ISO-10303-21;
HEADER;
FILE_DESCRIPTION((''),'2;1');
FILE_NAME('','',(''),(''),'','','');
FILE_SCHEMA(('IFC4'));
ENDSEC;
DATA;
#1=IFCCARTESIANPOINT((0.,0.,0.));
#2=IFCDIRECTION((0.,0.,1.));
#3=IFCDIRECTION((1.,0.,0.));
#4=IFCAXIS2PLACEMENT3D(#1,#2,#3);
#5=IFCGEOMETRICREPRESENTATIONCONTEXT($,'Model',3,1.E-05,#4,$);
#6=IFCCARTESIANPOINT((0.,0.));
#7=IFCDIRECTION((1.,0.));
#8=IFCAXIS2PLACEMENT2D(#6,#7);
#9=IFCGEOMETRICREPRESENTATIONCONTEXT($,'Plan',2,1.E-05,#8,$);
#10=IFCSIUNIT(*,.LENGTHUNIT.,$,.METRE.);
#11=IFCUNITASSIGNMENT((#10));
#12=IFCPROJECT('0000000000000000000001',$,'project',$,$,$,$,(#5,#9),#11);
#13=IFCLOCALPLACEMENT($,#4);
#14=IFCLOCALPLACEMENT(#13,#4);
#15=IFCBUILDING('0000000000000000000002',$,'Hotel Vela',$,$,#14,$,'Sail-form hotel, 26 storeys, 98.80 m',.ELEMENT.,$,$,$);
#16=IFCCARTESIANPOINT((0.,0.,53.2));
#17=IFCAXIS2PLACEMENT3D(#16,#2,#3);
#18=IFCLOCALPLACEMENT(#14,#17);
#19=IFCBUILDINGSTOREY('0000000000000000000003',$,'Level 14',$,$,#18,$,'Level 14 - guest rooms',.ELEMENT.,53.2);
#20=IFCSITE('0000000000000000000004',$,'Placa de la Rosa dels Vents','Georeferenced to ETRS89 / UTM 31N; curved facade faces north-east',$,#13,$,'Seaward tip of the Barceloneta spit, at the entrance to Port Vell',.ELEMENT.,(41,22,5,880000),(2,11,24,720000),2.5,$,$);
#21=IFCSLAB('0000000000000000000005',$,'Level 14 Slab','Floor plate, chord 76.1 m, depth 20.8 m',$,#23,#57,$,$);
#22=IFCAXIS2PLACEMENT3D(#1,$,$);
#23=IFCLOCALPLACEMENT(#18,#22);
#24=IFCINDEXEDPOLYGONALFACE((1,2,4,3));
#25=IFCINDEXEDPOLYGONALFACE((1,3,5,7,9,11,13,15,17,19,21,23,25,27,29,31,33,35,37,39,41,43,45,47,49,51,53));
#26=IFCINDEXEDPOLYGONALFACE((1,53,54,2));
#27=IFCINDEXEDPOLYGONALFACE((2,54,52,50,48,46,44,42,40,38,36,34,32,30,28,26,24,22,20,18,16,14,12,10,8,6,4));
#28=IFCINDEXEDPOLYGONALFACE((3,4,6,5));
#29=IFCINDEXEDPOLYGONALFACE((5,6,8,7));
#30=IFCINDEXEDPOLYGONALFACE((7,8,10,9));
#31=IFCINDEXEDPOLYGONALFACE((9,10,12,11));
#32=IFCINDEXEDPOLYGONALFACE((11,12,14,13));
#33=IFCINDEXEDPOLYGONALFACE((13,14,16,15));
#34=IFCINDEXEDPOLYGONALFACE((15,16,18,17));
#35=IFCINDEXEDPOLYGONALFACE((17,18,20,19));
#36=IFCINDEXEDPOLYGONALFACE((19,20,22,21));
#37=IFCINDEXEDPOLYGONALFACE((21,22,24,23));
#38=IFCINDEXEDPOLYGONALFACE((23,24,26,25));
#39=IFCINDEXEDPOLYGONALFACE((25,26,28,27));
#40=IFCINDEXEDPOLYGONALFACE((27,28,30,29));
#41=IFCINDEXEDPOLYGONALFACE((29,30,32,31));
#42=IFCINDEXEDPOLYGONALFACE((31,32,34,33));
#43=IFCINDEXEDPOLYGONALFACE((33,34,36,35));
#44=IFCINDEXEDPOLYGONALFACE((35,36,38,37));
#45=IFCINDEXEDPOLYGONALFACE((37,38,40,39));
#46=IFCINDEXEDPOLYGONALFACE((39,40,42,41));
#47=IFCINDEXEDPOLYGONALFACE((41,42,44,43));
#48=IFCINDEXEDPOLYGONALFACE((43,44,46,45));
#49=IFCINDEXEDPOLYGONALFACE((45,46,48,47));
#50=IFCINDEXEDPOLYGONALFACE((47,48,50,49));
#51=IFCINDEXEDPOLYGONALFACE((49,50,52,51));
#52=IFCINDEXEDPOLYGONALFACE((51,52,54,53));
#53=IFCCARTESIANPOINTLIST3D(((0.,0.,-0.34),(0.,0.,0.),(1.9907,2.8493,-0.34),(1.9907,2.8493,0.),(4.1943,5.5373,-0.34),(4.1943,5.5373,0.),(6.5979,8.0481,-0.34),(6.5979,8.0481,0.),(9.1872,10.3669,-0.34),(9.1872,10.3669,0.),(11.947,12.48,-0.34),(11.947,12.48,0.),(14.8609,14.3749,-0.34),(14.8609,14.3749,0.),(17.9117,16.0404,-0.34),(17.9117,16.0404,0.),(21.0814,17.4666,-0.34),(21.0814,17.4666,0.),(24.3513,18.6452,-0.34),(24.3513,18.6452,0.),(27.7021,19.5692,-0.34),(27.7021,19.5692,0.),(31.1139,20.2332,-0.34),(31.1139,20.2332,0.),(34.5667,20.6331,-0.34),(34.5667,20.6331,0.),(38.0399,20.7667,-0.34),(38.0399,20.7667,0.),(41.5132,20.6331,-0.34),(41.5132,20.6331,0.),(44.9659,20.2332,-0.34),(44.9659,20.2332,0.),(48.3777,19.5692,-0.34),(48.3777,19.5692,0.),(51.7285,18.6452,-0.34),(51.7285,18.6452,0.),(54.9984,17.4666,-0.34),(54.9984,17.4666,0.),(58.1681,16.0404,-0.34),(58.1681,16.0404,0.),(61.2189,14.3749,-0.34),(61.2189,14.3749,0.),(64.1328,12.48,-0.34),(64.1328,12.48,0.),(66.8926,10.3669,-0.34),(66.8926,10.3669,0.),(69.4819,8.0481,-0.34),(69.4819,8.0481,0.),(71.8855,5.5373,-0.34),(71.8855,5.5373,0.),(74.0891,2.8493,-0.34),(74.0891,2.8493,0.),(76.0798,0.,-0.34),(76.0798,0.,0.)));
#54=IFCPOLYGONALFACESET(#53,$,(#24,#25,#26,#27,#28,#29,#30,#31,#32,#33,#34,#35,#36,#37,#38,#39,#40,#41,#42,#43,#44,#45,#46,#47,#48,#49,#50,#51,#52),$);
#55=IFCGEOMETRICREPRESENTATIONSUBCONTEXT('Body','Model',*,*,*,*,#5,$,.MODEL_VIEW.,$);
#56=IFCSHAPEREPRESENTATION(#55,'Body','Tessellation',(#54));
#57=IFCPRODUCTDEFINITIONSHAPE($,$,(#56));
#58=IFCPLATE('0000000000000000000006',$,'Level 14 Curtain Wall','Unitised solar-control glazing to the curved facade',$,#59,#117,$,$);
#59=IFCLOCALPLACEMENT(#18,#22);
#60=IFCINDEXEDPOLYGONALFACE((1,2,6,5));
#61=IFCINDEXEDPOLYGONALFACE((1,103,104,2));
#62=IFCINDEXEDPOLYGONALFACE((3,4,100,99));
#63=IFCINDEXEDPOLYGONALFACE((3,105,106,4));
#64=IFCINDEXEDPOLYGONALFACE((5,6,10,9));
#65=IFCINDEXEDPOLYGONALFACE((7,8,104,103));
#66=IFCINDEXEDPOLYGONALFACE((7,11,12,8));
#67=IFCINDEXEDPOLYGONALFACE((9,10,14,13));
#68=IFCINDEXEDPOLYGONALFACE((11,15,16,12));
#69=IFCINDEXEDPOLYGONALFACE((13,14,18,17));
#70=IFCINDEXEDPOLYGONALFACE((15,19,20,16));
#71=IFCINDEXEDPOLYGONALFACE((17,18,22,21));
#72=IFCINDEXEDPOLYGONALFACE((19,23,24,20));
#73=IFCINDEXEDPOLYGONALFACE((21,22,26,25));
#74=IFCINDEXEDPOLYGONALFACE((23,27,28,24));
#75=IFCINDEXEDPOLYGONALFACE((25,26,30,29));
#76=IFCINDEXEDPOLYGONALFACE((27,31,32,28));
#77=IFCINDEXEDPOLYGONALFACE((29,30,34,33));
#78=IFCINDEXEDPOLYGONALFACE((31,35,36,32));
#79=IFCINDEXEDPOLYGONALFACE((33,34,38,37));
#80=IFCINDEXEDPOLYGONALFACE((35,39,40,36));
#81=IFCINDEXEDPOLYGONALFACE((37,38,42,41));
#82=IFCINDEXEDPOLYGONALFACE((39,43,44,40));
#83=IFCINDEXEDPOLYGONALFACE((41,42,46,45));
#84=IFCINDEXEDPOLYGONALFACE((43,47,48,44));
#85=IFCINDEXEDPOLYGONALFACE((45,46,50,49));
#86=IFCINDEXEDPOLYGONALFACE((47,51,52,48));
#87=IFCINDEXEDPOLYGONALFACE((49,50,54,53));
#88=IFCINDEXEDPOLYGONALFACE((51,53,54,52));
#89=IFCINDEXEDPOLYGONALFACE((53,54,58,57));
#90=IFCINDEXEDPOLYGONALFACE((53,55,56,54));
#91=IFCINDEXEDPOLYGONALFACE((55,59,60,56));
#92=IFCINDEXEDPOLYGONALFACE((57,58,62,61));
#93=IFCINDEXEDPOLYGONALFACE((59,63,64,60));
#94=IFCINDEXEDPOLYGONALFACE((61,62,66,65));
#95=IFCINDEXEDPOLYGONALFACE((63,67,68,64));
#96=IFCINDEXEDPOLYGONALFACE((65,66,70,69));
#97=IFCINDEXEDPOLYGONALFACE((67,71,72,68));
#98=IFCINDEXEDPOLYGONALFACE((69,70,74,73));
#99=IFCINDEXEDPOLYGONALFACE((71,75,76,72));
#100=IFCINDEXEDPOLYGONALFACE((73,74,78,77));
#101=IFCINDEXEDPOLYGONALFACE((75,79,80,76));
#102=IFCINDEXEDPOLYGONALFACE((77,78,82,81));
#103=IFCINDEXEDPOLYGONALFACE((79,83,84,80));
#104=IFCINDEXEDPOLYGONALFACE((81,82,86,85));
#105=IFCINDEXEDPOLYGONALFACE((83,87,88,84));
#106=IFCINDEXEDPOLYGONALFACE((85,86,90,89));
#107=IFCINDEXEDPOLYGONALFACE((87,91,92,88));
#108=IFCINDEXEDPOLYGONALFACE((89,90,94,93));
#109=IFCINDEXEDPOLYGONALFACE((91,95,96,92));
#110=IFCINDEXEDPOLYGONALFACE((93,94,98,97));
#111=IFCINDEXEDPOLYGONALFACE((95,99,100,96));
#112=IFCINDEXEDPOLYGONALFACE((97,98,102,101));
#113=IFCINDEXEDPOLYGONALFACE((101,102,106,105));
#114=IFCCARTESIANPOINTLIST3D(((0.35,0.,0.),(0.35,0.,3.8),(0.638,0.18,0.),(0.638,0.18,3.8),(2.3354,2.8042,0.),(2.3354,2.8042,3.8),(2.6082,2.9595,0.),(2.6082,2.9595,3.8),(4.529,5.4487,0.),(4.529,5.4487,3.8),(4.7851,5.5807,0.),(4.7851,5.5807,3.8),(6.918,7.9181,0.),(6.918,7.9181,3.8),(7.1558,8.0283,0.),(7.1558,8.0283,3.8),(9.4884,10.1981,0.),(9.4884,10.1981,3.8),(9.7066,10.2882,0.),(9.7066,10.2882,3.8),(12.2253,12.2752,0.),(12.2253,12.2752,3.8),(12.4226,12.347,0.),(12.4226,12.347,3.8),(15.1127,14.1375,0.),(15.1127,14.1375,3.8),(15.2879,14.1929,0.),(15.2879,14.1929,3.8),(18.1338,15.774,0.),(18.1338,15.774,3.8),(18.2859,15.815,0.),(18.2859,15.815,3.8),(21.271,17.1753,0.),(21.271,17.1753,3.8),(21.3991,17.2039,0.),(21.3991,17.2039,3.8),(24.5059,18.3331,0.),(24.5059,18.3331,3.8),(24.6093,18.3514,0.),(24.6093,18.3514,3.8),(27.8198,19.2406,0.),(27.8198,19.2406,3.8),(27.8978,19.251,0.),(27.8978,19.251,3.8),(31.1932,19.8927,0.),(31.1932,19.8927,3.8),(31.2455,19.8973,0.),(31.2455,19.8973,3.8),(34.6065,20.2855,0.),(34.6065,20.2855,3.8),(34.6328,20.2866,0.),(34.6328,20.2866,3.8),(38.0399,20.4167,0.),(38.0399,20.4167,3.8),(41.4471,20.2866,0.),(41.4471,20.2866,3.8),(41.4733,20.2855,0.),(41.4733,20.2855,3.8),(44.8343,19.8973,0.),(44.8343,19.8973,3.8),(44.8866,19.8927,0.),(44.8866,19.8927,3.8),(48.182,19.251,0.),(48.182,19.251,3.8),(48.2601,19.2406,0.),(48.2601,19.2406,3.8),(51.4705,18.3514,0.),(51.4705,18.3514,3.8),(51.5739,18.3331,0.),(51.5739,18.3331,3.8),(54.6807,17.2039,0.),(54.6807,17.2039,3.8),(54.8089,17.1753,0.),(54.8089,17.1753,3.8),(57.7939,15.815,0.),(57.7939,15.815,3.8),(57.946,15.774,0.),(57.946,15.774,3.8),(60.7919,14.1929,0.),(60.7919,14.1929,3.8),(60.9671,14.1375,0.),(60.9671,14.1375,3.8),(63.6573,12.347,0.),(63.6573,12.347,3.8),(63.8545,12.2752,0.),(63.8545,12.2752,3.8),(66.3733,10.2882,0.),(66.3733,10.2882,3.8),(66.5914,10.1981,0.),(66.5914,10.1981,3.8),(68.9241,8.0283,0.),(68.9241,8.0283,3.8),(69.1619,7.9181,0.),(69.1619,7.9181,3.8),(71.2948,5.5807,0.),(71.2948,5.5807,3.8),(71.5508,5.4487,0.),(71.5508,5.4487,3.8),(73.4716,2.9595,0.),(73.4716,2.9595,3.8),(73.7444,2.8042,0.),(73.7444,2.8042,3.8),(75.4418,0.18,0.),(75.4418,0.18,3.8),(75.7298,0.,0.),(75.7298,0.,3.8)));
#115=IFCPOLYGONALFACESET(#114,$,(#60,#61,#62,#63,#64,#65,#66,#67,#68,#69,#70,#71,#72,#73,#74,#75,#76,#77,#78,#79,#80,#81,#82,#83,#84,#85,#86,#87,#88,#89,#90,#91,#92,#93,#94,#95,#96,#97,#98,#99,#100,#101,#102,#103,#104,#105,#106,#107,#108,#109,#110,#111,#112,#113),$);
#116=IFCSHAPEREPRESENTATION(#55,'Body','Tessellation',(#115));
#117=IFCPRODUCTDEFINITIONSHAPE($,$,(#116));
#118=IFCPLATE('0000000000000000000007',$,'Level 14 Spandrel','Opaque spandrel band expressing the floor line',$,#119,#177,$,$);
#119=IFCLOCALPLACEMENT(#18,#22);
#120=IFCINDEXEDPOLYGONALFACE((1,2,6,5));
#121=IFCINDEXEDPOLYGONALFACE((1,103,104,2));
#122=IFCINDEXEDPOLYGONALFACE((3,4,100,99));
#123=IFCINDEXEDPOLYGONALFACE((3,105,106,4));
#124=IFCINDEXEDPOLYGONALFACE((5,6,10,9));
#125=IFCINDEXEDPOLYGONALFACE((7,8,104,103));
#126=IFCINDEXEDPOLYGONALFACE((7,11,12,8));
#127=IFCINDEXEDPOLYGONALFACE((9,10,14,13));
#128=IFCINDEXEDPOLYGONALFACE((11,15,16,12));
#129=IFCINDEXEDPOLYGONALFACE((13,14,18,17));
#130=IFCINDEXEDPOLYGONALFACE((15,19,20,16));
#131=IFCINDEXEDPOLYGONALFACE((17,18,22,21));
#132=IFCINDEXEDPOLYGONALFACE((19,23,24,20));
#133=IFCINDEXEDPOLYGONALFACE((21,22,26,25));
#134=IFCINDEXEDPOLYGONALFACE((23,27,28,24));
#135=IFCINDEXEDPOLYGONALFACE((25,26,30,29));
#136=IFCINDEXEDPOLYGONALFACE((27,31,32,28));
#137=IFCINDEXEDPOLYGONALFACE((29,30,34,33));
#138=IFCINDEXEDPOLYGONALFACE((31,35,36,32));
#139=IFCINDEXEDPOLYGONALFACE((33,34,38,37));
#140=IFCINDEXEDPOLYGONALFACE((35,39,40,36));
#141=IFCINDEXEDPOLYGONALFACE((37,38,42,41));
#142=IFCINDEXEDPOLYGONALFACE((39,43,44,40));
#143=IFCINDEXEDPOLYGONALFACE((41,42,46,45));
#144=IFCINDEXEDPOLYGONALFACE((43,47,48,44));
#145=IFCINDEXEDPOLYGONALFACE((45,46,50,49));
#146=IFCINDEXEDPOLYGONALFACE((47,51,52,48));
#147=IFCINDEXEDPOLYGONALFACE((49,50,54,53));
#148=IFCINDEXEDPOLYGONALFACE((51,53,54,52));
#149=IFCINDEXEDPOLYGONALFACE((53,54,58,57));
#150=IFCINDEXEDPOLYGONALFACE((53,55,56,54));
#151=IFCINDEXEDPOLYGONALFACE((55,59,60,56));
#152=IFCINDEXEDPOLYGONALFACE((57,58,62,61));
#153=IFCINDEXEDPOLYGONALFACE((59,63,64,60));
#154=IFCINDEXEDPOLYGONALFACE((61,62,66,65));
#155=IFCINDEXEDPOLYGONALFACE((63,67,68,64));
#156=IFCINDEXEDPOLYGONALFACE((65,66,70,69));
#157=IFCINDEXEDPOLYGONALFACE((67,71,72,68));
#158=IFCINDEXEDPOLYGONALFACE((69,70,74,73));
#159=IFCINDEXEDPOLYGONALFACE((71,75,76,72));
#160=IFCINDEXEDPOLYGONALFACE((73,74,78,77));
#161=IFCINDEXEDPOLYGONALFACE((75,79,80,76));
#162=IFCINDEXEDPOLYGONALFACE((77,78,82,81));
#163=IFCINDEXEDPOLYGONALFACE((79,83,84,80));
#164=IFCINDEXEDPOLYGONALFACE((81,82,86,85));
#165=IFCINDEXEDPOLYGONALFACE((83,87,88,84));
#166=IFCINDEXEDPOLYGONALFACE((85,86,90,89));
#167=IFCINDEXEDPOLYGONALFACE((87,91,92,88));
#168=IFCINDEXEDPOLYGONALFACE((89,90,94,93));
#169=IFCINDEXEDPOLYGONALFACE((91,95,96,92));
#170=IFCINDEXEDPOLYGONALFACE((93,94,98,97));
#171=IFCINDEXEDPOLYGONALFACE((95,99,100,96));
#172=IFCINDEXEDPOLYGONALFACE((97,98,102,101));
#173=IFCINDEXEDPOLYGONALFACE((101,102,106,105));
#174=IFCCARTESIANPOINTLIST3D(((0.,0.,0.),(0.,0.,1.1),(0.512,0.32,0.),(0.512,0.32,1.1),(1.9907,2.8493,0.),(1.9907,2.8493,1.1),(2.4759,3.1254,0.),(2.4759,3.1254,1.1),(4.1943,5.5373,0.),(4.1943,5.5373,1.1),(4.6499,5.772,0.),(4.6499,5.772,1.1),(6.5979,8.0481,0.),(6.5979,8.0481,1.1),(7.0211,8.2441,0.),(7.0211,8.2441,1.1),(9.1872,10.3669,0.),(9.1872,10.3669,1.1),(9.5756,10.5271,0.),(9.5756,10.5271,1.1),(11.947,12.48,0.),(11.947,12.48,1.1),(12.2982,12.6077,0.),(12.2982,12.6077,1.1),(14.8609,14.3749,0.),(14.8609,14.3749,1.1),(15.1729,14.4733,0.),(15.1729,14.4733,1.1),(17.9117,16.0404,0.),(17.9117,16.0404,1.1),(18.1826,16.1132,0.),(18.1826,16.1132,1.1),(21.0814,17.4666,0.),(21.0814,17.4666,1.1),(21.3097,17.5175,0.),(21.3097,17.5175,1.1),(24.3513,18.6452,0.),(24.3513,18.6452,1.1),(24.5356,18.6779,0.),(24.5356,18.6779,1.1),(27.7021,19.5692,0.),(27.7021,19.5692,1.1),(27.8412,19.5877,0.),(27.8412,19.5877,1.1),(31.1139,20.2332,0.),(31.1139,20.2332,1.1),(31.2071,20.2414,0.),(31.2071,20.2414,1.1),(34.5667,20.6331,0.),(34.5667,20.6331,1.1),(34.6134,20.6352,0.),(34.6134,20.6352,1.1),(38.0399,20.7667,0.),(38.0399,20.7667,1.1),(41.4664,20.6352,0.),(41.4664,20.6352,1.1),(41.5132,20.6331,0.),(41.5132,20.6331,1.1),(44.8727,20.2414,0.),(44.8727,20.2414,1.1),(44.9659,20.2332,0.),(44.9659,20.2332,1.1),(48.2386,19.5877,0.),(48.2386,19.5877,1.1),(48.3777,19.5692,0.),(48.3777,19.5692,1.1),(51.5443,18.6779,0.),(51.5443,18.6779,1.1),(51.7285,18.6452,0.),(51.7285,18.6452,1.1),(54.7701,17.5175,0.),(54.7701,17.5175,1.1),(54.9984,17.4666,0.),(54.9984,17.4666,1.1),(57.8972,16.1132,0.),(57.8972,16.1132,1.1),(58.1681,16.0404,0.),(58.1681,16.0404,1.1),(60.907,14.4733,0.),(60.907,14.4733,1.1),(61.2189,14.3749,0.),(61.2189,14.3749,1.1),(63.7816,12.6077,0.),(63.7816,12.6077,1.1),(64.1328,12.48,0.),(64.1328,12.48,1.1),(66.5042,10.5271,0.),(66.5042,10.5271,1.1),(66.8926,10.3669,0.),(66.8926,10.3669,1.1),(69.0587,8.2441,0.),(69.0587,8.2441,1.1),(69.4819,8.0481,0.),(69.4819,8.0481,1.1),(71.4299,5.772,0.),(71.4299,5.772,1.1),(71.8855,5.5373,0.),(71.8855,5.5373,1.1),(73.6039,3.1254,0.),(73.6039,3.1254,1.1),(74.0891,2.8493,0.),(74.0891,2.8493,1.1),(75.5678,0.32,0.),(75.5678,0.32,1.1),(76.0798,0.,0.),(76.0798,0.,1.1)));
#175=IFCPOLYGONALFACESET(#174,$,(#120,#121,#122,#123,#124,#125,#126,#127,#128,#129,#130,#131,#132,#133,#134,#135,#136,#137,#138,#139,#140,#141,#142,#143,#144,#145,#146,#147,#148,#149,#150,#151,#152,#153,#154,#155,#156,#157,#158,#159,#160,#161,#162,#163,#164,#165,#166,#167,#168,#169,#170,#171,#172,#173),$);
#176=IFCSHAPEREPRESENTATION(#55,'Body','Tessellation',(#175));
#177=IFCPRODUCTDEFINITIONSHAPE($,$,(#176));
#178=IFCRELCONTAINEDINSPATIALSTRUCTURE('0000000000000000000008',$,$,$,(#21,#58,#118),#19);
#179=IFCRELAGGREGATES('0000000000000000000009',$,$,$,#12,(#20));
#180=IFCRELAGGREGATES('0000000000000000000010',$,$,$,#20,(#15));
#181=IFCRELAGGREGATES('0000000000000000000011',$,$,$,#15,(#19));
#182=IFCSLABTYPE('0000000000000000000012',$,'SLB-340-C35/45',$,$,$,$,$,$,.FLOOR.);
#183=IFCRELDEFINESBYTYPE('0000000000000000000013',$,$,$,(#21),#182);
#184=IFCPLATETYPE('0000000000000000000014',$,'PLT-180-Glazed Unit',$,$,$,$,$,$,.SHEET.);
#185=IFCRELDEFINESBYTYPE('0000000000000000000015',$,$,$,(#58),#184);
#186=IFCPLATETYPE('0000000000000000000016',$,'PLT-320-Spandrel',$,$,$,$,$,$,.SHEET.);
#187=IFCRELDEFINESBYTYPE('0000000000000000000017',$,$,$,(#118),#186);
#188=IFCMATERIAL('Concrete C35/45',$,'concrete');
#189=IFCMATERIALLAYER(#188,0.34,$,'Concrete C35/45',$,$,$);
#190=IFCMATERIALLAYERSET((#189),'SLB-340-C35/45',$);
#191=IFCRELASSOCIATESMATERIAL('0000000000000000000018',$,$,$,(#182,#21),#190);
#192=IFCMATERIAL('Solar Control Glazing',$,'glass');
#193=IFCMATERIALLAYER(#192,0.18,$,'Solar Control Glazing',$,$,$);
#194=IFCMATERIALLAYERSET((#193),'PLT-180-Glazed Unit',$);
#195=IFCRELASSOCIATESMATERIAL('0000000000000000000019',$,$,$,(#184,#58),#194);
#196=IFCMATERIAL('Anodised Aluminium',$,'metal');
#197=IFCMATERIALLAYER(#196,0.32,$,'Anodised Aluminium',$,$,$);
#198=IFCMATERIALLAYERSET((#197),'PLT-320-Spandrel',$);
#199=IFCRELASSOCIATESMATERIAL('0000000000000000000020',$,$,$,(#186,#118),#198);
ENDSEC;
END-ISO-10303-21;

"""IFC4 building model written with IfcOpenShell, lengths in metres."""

from ifc_helpers import new_model, si_unit, frame, origin_with_axes, origin_2d_with_axis, place, context, subcontext, project, spatial, line, indexed_curve, outline, extrude, material, layer, layer_set, layer_usage, type_object, element, save


model = new_model("IFC4")

# Units and contexts
model_context = context("Model", 3, precision=1e-05, world=origin_with_axes())
plan_context = context("Plan", 2, precision=1e-05, world=origin_2d_with_axis())
body_context = subcontext(model_context, "Body", "Model", "MODEL_VIEW")
ifc_project = project(units=[si_unit("LENGTHUNIT", "METRE")], contexts=[model_context, plan_context])

# Site, building, storey
site_placement = place(None, origin_with_axes())
site = spatial("IfcSite", under=ifc_project, at=site_placement, Name="Placa de la Rosa dels Vents", Description="Georeferenced to ETRS89 / UTM 31N; curved facade faces north-east", LongName="Seaward tip of the Barceloneta spit, at the entrance to Port Vell", CompositionType="ELEMENT", RefLatitude=(41, 22, 5, 880000), RefLongitude=(2, 11, 24, 720000), RefElevation=2.5)
building_placement = place(site_placement, origin_with_axes())
building = spatial("IfcBuilding", under=site, at=building_placement, Name="Hotel Vela", LongName="Sail-form hotel, 26 storeys, 98.80 m", CompositionType="ELEMENT")
storey_placement = place(building_placement, frame((0.0, 0.0, 53.2), z_axis=(0.0, 0.0, 1.0), x_axis=(1.0, 0.0, 0.0)))
storey = spatial("IfcBuildingStorey", under=building, at=storey_placement, Name="Level 14", LongName="Level 14 - guest rooms", CompositionType="ELEMENT", Elevation=53.2)

# Slab
ifc_material_1 = material(Name="Concrete C35/45", Category="concrete")
ifc_layer_1 = layer(ifc_material_1, 0.34, Name="Concrete C35/45")
ifc_layer_set_1 = layer_set([ifc_layer_1], Name="SLB-340-C35/45")
ifc_layer_usage_1 = layer_usage(ifc_layer_set_1, "AXIS3", "POSITIVE", 0.0)
slab_type = type_object("IfcSlabType", Name="SLB-340-C35/45", PredefinedType="FLOOR", material=ifc_layer_set_1)
slab_placement = place(storey_placement, frame((0.0, 0.0, -0.34), z_axis=(0.0, 0.0, 1.0), x_axis=(1.0, 0.0, 0.0)))
element("IfcSlab", 1, at=slab_placement, inside=storey, type_object=slab_type, material=ifc_layer_usage_1, Name="Level 14 Slab", Description="Floor plate, chord 76.1 m, depth 20.8 m", context=body_context, shape_type="SweptSolid", body=[
    extrude(outline(indexed_curve([(0.0, 0.0), (76.0798, 0.0), (74.0891, 2.8493), (71.8855, 5.5373), (69.4819, 8.0481), (66.8926, 10.3669), (64.1328, 12.48), (61.2189, 14.3749), (58.1681, 16.0404), (54.9984, 17.4666), (51.7285, 18.6452), (48.3777, 19.5692), (44.9659, 20.2332), (41.5132, 20.6331), (38.0399, 20.7667), (34.5667, 20.6331), (31.1139, 20.2332), (27.7021, 19.5692), (24.3513, 18.6452), (21.0814, 17.4666), (17.9117, 16.0404), (14.8609, 14.3749), (11.947, 12.48), (9.1872, 10.3669), (6.5979, 8.0481), (4.1943, 5.5373), (1.9907, 2.8493)], segments=[line(1, 2, 3, 4, 5, 6, 7, 8, 9, 10, 11, 12, 13, 14, 15, 16, 17, 18, 19, 20, 21, 22, 23, 24, 25, 26, 27, 1)])), origin_with_axes(), (0.0, 0.0, 1.0), 0.34),
])

# Plates
ifc_material_2 = material(Name="Solar Control Glazing", Category="glass")
ifc_layer_2 = layer(ifc_material_2, 0.18, Name="Solar Control Glazing")
ifc_layer_set_2 = layer_set([ifc_layer_2], Name="PLT-180-Glazed Unit")
ifc_layer_usage_2 = layer_usage(ifc_layer_set_2, "AXIS2", "POSITIVE", 0.0)
plate_type_1 = type_object("IfcPlateType", Name="PLT-180-Glazed Unit", PredefinedType="SHEET", material=ifc_layer_set_2)
plate_1_placement = place(storey_placement, frame((0.35, 0.0, 0.0), z_axis=(0.0, 0.0, 1.0), x_axis=(1.0, 0.0, 0.0)))
element("IfcPlate", 2, at=plate_1_placement, inside=storey, type_object=plate_type_1, material=ifc_layer_usage_2, Name="Level 14 Curtain Wall", Description="Unitised solar-control glazing to the curved facade", context=body_context, shape_type="SweptSolid", body=[
    extrude(outline(indexed_curve([(75.3798, 0.0), (73.3944, 2.8042), (71.2008, 5.4487), (68.8119, 7.9181), (66.2414, 10.1981), (63.5045, 12.2752), (60.6171, 14.1375), (57.596, 15.774), (54.4589, 17.1753), (51.2239, 18.3331), (47.9101, 19.2406), (44.5366, 19.8927), (41.1233, 20.2855), (37.6899, 20.4167), (34.2565, 20.2855), (30.8432, 19.8927), (27.4698, 19.2406), (24.1559, 18.3331), (20.921, 17.1753), (17.7838, 15.774), (14.7627, 14.1375), (11.8753, 12.2752), (9.1384, 10.1981), (6.568, 7.9181), (4.179, 5.4487), (1.9854, 2.8042), (0.0, 0.0), (75.0918, 0.18), (2.2582, 2.9595), (4.4351, 5.5807), (6.8058, 8.0283), (9.3566, 10.2882), (12.0726, 12.347), (14.9379, 14.1929), (17.9359, 15.815), (21.0491, 17.2039), (24.2593, 18.3514), (27.5478, 19.251), (30.8955, 19.8973), (34.2828, 20.2866), (37.6899, 20.4167), (41.0971, 20.2866), (44.4843, 19.8973), (47.832, 19.251), (51.1205, 18.3514), (54.3307, 17.2039), (57.4439, 15.815), (60.4419, 14.1929), (63.3073, 12.347), (66.0233, 10.2882), (68.5741, 8.0283), (70.9448, 5.5807), (73.1216, 2.9595), (0.288, 0.18)], segments=[line(1, 2, 3, 4, 5, 6, 7, 8, 9, 10, 11, 12, 13, 14, 15, 16, 17, 18, 19, 20, 21, 22, 23, 24, 25, 26, 27, 28, 29, 30, 31, 32, 33, 34, 35, 36, 37, 38, 39, 40, 41, 42, 43, 44, 45, 46, 47, 48, 49, 50, 51, 52, 53, 54, 1)])), origin_with_axes(), (0.0, 0.0, 1.0), 3.8),
])
ifc_material_3 = material(Name="Anodised Aluminium", Category="metal")
ifc_layer_3 = layer(ifc_material_3, 0.32, Name="Anodised Aluminium")
ifc_layer_set_3 = layer_set([ifc_layer_3], Name="PLT-320-Spandrel")
ifc_layer_usage_3 = layer_usage(ifc_layer_set_3, "AXIS2", "POSITIVE", 0.0)
plate_type_2 = type_object("IfcPlateType", Name="PLT-320-Spandrel", PredefinedType="SHEET", material=ifc_layer_set_3)
plate_2_placement = place(storey_placement, origin_with_axes())
element("IfcPlate", 3, at=plate_2_placement, inside=storey, type_object=plate_type_2, material=ifc_layer_usage_3, Name="Level 14 Spandrel", Description="Opaque spandrel band expressing the floor line", context=body_context, shape_type="SweptSolid", body=[
    extrude(outline(indexed_curve([(76.0798, 0.0), (74.0891, 2.8493), (71.8855, 5.5373), (69.4819, 8.0481), (66.8926, 10.3669), (64.1328, 12.48), (61.2189, 14.3749), (58.1681, 16.0404), (54.9984, 17.4666), (51.7285, 18.6452), (48.3777, 19.5692), (44.9659, 20.2332), (41.5132, 20.6331), (38.0399, 20.7667), (34.5667, 20.6331), (31.1139, 20.2332), (27.7021, 19.5692), (24.3513, 18.6452), (21.0814, 17.4666), (17.9117, 16.0404), (14.8609, 14.3749), (11.947, 12.48), (9.1872, 10.3669), (6.5979, 8.0481), (4.1943, 5.5373), (1.9907, 2.8493), (0.0, 0.0), (75.5678, 0.32), (2.4759, 3.1254), (4.6499, 5.772), (7.0211, 8.2441), (9.5756, 10.5271), (12.2982, 12.6077), (15.1729, 14.4733), (18.1826, 16.1132), (21.3097, 17.5175), (24.5356, 18.6779), (27.8412, 19.5877), (31.2071, 20.2414), (34.6134, 20.6352), (38.0399, 20.7667), (41.4664, 20.6352), (44.8727, 20.2414), (48.2386, 19.5877), (51.5443, 18.6779), (54.7701, 17.5175), (57.8972, 16.1132), (60.907, 14.4733), (63.7816, 12.6077), (66.5042, 10.5271), (69.0587, 8.2441), (71.4299, 5.772), (73.6039, 3.1254), (0.512, 0.32)], segments=[line(1, 2, 3, 4, 5, 6, 7, 8, 9, 10, 11, 12, 13, 14, 15, 16, 17, 18, 19, 20, 21, 22, 23, 24, 25, 26, 27, 28, 29, 30, 31, 32, 33, 34, 35, 36, 37, 38, 39, 40, 41, 42, 43, 44, 45, 46, 47, 48, 49, 50, 51, 52, 53, 54, 1)])), origin_with_axes(), (0.0, 0.0, 1.0), 1.1),
])

save(model, "model.ifc")
